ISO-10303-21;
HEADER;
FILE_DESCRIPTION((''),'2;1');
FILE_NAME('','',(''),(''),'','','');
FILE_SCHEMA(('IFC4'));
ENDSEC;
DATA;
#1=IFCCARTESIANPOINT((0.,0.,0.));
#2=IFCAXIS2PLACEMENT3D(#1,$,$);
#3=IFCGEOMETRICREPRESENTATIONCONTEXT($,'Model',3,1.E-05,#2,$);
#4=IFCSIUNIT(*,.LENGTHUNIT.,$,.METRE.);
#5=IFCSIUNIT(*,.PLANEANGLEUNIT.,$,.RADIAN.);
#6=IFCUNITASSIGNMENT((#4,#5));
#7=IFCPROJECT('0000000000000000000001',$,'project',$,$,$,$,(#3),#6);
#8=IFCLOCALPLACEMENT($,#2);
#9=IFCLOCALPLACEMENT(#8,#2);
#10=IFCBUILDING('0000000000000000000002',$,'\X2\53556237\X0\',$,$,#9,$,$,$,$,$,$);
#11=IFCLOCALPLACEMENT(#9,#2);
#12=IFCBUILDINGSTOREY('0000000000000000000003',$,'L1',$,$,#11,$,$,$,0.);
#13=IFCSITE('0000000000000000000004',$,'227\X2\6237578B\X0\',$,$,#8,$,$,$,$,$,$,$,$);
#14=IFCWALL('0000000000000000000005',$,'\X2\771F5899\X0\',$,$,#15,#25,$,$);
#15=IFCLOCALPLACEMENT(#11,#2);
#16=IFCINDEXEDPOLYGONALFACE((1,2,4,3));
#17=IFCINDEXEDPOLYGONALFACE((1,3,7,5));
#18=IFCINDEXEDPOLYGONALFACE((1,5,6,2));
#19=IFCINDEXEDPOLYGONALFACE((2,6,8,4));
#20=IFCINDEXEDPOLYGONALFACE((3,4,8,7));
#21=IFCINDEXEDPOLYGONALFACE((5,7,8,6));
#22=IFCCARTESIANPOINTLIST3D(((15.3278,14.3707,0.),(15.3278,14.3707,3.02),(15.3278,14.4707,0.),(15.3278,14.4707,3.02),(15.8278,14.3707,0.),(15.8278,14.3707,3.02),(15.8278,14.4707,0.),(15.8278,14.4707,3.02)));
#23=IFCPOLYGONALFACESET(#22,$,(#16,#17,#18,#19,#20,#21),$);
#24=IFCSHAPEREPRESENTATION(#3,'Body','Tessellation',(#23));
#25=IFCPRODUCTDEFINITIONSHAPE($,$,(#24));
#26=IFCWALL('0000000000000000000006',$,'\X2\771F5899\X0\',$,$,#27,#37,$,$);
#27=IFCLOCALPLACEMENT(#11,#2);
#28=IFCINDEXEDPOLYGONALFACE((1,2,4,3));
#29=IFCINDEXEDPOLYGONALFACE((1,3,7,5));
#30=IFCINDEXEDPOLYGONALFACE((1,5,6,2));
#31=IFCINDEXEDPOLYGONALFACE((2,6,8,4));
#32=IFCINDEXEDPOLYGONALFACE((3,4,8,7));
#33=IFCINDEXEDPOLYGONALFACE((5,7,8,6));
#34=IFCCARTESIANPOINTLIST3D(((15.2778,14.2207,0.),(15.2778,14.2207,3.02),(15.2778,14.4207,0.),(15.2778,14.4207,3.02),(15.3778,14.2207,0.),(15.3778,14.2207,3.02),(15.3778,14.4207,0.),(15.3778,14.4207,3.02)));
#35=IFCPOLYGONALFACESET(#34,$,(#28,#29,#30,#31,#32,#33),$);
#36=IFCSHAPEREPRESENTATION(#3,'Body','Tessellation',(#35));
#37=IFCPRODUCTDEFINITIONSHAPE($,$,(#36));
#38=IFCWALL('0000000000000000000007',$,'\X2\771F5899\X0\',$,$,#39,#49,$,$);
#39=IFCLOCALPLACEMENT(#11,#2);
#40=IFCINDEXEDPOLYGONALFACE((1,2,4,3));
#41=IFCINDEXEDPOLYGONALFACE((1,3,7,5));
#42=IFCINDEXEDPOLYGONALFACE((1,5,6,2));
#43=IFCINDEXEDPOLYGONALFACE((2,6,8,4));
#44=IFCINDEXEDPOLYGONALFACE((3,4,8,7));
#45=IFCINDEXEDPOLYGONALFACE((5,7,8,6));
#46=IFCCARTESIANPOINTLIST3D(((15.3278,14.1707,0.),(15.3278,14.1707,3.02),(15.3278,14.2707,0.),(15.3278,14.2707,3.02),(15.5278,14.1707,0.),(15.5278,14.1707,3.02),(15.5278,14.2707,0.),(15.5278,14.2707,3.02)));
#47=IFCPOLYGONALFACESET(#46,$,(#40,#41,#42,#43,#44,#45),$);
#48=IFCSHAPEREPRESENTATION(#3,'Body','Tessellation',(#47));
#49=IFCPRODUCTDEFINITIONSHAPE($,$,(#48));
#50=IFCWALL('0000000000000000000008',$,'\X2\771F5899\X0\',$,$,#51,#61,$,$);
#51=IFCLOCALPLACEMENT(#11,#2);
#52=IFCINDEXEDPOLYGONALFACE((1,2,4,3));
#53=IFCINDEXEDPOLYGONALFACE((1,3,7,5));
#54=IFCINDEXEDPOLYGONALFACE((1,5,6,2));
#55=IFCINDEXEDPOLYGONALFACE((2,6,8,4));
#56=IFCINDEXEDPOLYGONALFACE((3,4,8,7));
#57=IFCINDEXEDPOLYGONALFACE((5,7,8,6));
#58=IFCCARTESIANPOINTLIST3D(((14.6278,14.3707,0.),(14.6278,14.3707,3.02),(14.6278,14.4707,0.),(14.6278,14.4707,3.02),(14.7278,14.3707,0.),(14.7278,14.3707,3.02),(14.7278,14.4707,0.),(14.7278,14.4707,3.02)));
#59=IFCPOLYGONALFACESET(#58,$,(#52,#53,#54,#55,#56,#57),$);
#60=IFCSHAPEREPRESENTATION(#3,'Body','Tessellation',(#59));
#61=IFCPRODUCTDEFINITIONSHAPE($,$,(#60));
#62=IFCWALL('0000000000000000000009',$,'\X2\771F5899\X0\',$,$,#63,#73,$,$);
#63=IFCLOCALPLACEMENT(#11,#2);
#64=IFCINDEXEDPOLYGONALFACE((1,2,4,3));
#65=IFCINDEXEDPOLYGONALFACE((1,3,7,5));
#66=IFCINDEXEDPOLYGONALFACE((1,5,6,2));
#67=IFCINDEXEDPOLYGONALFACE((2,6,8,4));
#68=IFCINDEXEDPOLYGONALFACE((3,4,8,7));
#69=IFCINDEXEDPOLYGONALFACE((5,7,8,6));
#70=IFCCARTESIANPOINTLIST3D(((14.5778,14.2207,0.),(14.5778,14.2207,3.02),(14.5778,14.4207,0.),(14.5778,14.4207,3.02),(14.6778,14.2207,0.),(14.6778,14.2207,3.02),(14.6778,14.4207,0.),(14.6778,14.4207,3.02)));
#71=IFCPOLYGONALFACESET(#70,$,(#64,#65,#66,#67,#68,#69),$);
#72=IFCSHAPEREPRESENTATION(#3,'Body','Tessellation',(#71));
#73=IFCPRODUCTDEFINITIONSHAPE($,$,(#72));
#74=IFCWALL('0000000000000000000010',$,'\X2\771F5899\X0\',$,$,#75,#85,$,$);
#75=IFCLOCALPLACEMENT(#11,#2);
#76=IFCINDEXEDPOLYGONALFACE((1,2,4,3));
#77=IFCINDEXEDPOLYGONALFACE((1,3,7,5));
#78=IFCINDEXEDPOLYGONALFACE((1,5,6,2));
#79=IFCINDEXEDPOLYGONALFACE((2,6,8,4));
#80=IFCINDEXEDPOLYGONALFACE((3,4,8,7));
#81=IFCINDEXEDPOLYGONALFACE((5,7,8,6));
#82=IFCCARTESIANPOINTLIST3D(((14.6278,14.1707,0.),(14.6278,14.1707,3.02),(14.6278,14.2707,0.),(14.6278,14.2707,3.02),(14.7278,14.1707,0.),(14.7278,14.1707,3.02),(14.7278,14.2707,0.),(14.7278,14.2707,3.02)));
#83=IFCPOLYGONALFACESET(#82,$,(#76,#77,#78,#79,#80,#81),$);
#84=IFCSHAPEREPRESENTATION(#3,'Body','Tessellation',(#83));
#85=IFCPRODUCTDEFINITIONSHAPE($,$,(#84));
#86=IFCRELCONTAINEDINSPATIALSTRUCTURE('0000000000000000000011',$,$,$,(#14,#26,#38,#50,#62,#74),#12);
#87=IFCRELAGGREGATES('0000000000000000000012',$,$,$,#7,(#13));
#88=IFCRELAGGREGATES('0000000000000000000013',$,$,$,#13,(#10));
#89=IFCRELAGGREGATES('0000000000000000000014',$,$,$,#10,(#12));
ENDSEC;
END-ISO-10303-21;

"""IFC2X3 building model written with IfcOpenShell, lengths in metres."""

from ifc_helpers import new_model, si_unit, origin, place, context, project, spatial, polyline, outline, extrude, element, save


model = new_model("IFC2X3")

# Units and contexts
model_context = context("Model", 3, precision=1e-05, world=origin())
ifc_project = project(units=[si_unit("LENGTHUNIT", "METRE"), si_unit("PLANEANGLEUNIT", "RADIAN")], contexts=[model_context])

# Site, building, storey
site_placement = place(None, origin())
site = spatial("IfcSite", under=ifc_project, at=site_placement, Name="227户型")
building_placement = place(site_placement, origin())
building = spatial("IfcBuilding", under=site, at=building_placement, Name="单户")
storey_placement = place(building_placement, origin())
storey = spatial("IfcBuildingStorey", under=building, at=storey_placement, Name="L1", Elevation=0.0)

# Walls
wall_1_placement = place(storey_placement, origin())
element("IfcWall", 1, at=wall_1_placement, inside=storey, Name="真墙", context=model_context, shape_type="SweptSolid", body=[
    extrude(outline(polyline([(15.8278, 14.3707), (15.3278, 14.3707), (15.3278, 14.4707), (15.8278, 14.4707), (15.8278, 14.3707)])), origin(), (0.0, 0.0, 1.0), 3.02),
])
wall_2_placement = place(storey_placement, origin())
element("IfcWall", 2, at=wall_2_placement, inside=storey, Name="真墙", context=model_context, shape_type="SweptSolid", body=[
    extrude(outline(polyline([(15.3778, 14.4207), (15.3778, 14.2207), (15.2778, 14.2207), (15.2778, 14.4207), (15.3778, 14.4207)])), origin(), (0.0, 0.0, 1.0), 3.02),
])
wall_3_placement = place(storey_placement, origin())
element("IfcWall", 3, at=wall_3_placement, inside=storey, Name="真墙", context=model_context, shape_type="SweptSolid", body=[
    extrude(outline(polyline([(15.3278, 14.2707), (15.5278, 14.2707), (15.5278, 14.1707), (15.3278, 14.1707), (15.3278, 14.2707)])), origin(), (0.0, 0.0, 1.0), 3.02),
])
wall_4_placement = place(storey_placement, origin())
element("IfcWall", 4, at=wall_4_placement, inside=storey, Name="真墙", context=model_context, shape_type="SweptSolid", body=[
    extrude(outline(polyline([(14.7278, 14.3707), (14.6278, 14.3707), (14.6278, 14.4707), (14.7278, 14.4707), (14.7278, 14.3707)])), origin(), (0.0, 0.0, 1.0), 3.02),
])
wall_5_placement = place(storey_placement, origin())
element("IfcWall", 5, at=wall_5_placement, inside=storey, Name="真墙", context=model_context, shape_type="SweptSolid", body=[
    extrude(outline(polyline([(14.6778, 14.4207), (14.6778, 14.2207), (14.5778, 14.2207), (14.5778, 14.4207), (14.6778, 14.4207)])), origin(), (0.0, 0.0, 1.0), 3.02),
])
wall_6_placement = place(storey_placement, origin())
element("IfcWall", 6, at=wall_6_placement, inside=storey, Name="真墙", context=model_context, shape_type="SweptSolid", body=[
    extrude(outline(polyline([(14.6278, 14.2707), (14.7278, 14.2707), (14.7278, 14.1707), (14.6278, 14.1707), (14.6278, 14.2707)])), origin(), (0.0, 0.0, 1.0), 3.02),
])

save(model, "model.ifc")
